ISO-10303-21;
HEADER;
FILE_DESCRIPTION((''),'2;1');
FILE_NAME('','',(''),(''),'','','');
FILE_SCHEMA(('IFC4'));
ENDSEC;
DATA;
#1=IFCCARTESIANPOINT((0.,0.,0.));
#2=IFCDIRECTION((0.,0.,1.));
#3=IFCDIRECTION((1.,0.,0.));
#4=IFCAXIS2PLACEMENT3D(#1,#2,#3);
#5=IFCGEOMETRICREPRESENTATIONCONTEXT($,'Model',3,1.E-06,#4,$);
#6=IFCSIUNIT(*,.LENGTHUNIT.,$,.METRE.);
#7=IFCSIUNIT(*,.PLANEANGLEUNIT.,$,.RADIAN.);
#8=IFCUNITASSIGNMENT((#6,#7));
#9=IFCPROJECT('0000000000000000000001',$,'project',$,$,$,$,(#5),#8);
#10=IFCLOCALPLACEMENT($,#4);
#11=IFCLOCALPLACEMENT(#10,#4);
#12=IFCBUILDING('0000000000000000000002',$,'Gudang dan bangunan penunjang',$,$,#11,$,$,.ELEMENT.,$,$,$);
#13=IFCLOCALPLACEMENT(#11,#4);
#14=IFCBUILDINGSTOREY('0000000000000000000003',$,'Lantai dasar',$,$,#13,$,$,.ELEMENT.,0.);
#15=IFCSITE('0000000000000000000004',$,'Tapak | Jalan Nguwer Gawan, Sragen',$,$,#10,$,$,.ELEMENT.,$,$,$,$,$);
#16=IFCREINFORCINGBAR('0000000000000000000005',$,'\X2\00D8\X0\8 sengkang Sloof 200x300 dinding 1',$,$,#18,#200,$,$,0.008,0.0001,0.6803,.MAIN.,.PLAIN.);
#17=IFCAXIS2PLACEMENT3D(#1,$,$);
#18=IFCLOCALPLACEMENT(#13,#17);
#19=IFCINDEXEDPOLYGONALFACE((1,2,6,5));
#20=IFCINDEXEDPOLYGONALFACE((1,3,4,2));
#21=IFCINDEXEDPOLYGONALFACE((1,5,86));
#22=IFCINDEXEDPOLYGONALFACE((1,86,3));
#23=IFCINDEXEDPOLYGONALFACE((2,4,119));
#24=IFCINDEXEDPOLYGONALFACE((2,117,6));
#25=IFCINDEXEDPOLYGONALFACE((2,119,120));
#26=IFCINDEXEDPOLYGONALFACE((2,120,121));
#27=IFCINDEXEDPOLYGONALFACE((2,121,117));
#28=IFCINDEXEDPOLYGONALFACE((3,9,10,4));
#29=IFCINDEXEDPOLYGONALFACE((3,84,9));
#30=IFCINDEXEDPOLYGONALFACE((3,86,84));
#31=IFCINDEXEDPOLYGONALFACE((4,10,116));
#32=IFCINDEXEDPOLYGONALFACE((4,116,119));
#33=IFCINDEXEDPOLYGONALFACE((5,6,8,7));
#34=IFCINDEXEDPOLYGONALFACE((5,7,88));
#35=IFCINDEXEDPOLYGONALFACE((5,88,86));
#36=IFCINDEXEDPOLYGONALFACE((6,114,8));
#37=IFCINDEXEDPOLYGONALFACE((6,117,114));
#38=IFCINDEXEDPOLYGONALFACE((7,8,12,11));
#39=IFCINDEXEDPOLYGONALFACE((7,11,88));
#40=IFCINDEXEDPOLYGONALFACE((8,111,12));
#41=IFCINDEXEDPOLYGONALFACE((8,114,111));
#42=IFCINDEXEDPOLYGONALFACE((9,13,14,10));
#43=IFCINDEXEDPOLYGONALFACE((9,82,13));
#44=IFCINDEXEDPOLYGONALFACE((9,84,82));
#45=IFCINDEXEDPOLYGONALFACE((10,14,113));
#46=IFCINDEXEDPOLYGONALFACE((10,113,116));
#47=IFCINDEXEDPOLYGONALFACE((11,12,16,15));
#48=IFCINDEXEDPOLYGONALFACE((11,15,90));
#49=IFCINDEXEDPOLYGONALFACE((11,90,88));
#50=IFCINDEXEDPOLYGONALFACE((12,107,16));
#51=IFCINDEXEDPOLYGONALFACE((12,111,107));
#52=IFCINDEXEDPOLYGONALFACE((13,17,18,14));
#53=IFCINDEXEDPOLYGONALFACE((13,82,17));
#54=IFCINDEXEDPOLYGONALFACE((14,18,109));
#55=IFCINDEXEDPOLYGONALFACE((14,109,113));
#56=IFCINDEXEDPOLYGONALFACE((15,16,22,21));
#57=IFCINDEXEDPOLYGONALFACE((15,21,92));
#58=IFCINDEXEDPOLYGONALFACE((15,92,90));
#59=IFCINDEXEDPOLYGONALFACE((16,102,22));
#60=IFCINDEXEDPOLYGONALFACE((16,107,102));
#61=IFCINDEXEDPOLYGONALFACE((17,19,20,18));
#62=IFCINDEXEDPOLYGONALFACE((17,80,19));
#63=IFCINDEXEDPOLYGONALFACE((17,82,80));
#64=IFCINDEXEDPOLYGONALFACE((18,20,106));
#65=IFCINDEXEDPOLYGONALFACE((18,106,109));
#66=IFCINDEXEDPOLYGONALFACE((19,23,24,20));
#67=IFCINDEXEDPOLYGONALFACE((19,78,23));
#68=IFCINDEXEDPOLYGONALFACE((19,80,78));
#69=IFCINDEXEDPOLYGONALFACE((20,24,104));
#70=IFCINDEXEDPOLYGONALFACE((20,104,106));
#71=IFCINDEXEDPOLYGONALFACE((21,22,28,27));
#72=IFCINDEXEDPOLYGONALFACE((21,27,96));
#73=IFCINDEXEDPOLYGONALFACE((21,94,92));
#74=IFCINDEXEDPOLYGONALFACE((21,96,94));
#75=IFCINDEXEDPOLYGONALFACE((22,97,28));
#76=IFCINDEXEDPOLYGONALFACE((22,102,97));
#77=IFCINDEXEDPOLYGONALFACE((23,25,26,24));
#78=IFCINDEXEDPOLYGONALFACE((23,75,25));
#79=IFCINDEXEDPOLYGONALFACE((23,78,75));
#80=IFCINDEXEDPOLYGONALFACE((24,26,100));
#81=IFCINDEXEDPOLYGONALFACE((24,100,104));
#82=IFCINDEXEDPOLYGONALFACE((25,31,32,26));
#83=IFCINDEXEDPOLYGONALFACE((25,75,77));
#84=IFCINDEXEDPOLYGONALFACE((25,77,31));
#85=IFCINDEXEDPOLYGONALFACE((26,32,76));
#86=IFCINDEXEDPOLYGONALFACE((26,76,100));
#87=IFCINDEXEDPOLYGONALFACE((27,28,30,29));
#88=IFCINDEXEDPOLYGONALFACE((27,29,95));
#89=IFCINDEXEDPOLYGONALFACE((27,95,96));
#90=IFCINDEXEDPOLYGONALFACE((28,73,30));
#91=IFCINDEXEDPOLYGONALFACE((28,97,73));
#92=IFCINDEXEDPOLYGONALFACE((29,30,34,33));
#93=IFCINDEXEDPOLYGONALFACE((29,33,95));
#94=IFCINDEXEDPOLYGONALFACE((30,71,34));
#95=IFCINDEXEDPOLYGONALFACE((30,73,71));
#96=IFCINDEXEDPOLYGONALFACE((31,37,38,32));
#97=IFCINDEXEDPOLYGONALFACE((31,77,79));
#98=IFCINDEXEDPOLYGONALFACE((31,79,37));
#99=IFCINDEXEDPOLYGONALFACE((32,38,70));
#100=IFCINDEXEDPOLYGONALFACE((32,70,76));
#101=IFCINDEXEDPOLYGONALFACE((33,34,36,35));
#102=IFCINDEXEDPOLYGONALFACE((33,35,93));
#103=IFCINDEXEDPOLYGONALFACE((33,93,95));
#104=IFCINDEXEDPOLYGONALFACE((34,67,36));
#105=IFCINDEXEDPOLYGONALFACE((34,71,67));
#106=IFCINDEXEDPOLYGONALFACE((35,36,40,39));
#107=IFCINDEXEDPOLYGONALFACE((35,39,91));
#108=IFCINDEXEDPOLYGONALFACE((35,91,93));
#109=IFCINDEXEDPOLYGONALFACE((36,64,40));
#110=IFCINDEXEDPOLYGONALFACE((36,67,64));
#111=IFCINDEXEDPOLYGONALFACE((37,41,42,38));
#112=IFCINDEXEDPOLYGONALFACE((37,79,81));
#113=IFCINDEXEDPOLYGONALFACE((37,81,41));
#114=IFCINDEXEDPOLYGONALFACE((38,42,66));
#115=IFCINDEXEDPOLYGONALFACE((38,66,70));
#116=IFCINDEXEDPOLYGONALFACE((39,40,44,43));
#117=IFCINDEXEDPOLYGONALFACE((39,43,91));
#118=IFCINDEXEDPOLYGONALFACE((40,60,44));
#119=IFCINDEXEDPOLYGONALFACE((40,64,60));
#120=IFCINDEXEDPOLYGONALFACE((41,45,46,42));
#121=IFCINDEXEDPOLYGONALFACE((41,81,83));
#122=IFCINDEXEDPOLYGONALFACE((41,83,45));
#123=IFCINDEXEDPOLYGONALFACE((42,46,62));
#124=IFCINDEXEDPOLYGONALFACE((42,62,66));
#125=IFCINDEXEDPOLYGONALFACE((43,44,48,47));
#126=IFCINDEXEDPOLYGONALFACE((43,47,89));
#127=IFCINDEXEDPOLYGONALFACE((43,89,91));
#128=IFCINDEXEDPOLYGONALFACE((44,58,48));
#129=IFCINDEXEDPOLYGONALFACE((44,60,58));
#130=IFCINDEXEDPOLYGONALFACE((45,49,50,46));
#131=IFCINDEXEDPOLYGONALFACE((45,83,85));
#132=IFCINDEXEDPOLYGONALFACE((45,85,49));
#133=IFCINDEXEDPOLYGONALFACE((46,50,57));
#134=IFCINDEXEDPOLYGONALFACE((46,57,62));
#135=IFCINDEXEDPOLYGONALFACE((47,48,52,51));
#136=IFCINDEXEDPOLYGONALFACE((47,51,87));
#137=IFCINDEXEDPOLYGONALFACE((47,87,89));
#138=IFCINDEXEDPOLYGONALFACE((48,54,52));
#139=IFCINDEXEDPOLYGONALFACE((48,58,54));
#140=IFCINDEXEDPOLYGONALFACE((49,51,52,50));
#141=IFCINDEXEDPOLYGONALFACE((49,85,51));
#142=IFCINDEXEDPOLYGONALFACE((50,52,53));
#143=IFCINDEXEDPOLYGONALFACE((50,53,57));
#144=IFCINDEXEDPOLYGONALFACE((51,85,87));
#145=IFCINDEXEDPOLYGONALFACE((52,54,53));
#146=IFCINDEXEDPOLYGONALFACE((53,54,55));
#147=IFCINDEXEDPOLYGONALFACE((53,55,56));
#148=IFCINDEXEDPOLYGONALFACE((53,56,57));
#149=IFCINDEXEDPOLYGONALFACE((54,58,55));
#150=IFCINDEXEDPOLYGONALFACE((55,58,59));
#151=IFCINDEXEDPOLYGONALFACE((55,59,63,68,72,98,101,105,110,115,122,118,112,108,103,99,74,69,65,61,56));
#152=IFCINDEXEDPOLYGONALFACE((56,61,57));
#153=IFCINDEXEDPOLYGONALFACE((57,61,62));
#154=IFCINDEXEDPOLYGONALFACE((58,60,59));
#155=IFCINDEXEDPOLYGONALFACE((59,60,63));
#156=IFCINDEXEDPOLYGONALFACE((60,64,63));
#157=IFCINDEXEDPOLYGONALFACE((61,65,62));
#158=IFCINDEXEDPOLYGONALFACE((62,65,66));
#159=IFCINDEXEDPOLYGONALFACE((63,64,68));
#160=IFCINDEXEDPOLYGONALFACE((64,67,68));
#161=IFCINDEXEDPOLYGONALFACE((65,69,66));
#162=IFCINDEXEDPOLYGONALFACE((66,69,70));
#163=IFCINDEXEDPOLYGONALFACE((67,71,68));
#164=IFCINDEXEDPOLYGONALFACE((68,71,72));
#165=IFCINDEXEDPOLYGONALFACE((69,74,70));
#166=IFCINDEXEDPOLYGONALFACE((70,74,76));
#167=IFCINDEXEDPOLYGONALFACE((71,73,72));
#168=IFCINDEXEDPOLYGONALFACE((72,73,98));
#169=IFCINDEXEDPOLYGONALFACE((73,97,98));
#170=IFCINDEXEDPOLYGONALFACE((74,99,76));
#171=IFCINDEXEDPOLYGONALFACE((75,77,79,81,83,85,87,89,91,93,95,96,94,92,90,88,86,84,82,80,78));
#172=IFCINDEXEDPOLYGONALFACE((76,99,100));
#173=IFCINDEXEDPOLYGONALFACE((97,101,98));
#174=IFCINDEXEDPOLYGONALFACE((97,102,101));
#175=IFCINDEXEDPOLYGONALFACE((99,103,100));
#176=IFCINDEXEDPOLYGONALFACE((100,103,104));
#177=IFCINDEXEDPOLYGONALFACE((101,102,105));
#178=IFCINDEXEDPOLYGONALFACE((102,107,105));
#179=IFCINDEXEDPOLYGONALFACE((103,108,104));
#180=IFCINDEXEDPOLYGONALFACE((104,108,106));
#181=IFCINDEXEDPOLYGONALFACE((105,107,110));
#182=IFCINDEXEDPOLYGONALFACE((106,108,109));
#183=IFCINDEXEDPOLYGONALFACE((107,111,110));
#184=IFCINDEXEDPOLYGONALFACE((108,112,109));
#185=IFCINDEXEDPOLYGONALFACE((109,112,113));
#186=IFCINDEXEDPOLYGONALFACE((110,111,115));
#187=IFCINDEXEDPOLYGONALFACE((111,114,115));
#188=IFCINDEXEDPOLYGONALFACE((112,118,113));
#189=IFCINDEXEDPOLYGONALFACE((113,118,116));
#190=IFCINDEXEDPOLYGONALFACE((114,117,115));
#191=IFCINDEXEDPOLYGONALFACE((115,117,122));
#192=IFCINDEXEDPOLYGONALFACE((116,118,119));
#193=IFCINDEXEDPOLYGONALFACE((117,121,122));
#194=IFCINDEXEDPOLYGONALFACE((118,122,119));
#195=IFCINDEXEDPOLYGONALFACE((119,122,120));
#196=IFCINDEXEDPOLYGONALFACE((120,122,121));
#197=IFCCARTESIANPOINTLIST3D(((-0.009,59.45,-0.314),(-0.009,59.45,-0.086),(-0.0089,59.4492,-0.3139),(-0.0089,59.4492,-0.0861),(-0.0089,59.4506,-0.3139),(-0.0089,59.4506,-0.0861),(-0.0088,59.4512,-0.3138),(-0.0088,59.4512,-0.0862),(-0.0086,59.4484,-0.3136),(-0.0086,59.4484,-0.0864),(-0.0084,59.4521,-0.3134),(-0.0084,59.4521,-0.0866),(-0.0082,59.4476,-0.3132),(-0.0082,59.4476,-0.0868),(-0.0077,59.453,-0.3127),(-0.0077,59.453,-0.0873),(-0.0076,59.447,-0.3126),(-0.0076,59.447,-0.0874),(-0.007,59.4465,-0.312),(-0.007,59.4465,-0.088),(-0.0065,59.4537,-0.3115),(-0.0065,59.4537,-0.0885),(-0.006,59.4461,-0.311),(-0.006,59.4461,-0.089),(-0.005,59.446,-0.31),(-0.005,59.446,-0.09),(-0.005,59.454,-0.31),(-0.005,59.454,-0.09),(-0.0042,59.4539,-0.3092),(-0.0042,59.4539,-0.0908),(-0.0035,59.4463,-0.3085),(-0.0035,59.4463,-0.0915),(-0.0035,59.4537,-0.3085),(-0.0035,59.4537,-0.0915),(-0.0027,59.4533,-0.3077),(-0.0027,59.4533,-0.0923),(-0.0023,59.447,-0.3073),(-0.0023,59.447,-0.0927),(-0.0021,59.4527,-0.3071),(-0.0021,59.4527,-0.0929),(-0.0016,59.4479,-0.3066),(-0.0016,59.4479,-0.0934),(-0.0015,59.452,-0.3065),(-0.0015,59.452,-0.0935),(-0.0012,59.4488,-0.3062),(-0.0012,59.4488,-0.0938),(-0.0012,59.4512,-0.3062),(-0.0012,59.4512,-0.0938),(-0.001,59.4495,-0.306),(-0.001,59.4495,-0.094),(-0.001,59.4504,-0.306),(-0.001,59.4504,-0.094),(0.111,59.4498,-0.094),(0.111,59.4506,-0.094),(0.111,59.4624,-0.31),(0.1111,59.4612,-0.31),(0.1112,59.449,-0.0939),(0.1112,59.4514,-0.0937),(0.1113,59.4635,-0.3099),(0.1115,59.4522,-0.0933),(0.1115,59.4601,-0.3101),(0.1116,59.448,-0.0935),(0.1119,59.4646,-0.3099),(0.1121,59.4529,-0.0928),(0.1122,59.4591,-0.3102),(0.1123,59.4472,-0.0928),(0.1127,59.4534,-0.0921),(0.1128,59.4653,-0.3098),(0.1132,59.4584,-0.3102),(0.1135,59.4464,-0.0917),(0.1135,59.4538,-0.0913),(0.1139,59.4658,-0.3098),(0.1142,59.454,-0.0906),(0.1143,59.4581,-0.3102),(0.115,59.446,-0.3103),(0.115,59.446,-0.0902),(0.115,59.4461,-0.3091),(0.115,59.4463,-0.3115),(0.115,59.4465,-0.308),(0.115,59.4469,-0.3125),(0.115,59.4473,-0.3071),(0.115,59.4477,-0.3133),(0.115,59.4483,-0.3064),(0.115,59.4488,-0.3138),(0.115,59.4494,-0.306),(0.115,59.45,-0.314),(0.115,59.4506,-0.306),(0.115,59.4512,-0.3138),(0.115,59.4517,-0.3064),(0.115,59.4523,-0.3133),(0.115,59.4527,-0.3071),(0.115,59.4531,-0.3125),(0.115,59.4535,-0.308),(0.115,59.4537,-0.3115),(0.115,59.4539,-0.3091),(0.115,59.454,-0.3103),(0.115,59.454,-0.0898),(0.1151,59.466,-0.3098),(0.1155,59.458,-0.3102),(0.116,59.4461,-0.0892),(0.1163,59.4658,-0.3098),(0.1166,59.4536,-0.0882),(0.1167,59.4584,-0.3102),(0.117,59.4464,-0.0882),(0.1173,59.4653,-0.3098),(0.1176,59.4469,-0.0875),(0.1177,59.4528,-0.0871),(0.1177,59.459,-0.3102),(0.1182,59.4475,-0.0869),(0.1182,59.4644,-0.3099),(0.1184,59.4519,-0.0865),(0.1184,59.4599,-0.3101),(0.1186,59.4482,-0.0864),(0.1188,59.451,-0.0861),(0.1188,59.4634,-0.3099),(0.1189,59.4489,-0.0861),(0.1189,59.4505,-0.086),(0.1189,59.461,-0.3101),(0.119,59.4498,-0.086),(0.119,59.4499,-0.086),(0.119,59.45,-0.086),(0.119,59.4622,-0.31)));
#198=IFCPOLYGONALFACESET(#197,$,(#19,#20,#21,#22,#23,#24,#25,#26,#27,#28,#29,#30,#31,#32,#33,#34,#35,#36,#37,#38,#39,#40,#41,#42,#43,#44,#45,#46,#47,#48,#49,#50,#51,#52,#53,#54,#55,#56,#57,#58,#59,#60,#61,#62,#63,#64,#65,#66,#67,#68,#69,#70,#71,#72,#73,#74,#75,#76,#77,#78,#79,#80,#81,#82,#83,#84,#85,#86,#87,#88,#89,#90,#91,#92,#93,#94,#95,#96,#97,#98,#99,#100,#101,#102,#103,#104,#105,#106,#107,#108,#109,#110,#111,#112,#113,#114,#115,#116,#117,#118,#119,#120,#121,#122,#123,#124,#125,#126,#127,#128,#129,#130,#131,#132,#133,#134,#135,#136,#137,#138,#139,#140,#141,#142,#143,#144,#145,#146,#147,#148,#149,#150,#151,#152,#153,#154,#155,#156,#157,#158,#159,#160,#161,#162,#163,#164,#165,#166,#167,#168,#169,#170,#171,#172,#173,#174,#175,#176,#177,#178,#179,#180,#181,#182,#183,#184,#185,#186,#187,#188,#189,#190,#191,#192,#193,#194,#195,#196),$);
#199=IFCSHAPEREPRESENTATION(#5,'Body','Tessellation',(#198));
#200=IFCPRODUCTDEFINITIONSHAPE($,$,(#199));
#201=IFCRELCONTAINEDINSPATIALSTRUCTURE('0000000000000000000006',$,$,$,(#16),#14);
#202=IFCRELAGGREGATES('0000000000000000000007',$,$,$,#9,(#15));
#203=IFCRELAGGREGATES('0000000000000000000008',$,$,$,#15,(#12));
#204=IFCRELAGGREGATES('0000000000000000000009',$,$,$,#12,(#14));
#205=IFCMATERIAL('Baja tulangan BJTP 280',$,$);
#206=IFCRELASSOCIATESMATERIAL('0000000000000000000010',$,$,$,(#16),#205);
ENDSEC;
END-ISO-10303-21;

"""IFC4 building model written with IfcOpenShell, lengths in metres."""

from ifc_helpers import new_model, entity, si_unit, origin_with_axes, place, context, project, spatial, material, element, save


model = new_model("IFC4")

# Units and contexts
model_context = context("Model", 3, precision=1e-06, world=origin_with_axes())
ifc_project = project(units=[si_unit("LENGTHUNIT", "METRE"), si_unit("PLANEANGLEUNIT", "RADIAN")], contexts=[model_context])

# Site, building, storey
site_placement = place(None, origin_with_axes())
site = spatial("IfcSite", under=ifc_project, at=site_placement, Name="Tapak | Jalan Nguwer Gawan, Sragen", CompositionType="ELEMENT")
building_placement = place(site_placement, origin_with_axes())
building = spatial("IfcBuilding", under=site, at=building_placement, Name="Gudang dan bangunan penunjang", CompositionType="ELEMENT")
storey_placement = place(building_placement, origin_with_axes())
storey = spatial("IfcBuildingStorey", under=building, at=storey_placement, Name="Lantai dasar", CompositionType="ELEMENT", Elevation=0.0)

# Shared definitions
placement = place(None, origin_with_axes())

# Reinforcing bar
ifc_material_1 = material(Name="Baja tulangan BJTP 280")
element("IfcReinforcingBar", 1, at=placement, inside=storey, material=ifc_material_1, Name="Ø8 sengkang Sloof 200x300 dinding 1", BarLength=0.6803, BarSurface="PLAIN", CrossSectionArea=0.0001, NominalDiameter=0.008, PredefinedType="MAIN", context=model_context, shape_type="AdvancedSweptSolid", body=[
    entity("IfcSweptDiskSolid", entity("IfcPolyline", [entity("IfcCartesianPoint", [0.115, 59.45, -0.31]), entity("IfcCartesianPoint", [-0.005, 59.45, -0.31]), entity("IfcCartesianPoint", [-0.005, 59.45, -0.09]), entity("IfcCartesianPoint", [0.115, 59.45, -0.09]), entity("IfcCartesianPoint", [0.115, 59.462, -0.31])]), 0.004),
])

save(model, "model.ifc")
